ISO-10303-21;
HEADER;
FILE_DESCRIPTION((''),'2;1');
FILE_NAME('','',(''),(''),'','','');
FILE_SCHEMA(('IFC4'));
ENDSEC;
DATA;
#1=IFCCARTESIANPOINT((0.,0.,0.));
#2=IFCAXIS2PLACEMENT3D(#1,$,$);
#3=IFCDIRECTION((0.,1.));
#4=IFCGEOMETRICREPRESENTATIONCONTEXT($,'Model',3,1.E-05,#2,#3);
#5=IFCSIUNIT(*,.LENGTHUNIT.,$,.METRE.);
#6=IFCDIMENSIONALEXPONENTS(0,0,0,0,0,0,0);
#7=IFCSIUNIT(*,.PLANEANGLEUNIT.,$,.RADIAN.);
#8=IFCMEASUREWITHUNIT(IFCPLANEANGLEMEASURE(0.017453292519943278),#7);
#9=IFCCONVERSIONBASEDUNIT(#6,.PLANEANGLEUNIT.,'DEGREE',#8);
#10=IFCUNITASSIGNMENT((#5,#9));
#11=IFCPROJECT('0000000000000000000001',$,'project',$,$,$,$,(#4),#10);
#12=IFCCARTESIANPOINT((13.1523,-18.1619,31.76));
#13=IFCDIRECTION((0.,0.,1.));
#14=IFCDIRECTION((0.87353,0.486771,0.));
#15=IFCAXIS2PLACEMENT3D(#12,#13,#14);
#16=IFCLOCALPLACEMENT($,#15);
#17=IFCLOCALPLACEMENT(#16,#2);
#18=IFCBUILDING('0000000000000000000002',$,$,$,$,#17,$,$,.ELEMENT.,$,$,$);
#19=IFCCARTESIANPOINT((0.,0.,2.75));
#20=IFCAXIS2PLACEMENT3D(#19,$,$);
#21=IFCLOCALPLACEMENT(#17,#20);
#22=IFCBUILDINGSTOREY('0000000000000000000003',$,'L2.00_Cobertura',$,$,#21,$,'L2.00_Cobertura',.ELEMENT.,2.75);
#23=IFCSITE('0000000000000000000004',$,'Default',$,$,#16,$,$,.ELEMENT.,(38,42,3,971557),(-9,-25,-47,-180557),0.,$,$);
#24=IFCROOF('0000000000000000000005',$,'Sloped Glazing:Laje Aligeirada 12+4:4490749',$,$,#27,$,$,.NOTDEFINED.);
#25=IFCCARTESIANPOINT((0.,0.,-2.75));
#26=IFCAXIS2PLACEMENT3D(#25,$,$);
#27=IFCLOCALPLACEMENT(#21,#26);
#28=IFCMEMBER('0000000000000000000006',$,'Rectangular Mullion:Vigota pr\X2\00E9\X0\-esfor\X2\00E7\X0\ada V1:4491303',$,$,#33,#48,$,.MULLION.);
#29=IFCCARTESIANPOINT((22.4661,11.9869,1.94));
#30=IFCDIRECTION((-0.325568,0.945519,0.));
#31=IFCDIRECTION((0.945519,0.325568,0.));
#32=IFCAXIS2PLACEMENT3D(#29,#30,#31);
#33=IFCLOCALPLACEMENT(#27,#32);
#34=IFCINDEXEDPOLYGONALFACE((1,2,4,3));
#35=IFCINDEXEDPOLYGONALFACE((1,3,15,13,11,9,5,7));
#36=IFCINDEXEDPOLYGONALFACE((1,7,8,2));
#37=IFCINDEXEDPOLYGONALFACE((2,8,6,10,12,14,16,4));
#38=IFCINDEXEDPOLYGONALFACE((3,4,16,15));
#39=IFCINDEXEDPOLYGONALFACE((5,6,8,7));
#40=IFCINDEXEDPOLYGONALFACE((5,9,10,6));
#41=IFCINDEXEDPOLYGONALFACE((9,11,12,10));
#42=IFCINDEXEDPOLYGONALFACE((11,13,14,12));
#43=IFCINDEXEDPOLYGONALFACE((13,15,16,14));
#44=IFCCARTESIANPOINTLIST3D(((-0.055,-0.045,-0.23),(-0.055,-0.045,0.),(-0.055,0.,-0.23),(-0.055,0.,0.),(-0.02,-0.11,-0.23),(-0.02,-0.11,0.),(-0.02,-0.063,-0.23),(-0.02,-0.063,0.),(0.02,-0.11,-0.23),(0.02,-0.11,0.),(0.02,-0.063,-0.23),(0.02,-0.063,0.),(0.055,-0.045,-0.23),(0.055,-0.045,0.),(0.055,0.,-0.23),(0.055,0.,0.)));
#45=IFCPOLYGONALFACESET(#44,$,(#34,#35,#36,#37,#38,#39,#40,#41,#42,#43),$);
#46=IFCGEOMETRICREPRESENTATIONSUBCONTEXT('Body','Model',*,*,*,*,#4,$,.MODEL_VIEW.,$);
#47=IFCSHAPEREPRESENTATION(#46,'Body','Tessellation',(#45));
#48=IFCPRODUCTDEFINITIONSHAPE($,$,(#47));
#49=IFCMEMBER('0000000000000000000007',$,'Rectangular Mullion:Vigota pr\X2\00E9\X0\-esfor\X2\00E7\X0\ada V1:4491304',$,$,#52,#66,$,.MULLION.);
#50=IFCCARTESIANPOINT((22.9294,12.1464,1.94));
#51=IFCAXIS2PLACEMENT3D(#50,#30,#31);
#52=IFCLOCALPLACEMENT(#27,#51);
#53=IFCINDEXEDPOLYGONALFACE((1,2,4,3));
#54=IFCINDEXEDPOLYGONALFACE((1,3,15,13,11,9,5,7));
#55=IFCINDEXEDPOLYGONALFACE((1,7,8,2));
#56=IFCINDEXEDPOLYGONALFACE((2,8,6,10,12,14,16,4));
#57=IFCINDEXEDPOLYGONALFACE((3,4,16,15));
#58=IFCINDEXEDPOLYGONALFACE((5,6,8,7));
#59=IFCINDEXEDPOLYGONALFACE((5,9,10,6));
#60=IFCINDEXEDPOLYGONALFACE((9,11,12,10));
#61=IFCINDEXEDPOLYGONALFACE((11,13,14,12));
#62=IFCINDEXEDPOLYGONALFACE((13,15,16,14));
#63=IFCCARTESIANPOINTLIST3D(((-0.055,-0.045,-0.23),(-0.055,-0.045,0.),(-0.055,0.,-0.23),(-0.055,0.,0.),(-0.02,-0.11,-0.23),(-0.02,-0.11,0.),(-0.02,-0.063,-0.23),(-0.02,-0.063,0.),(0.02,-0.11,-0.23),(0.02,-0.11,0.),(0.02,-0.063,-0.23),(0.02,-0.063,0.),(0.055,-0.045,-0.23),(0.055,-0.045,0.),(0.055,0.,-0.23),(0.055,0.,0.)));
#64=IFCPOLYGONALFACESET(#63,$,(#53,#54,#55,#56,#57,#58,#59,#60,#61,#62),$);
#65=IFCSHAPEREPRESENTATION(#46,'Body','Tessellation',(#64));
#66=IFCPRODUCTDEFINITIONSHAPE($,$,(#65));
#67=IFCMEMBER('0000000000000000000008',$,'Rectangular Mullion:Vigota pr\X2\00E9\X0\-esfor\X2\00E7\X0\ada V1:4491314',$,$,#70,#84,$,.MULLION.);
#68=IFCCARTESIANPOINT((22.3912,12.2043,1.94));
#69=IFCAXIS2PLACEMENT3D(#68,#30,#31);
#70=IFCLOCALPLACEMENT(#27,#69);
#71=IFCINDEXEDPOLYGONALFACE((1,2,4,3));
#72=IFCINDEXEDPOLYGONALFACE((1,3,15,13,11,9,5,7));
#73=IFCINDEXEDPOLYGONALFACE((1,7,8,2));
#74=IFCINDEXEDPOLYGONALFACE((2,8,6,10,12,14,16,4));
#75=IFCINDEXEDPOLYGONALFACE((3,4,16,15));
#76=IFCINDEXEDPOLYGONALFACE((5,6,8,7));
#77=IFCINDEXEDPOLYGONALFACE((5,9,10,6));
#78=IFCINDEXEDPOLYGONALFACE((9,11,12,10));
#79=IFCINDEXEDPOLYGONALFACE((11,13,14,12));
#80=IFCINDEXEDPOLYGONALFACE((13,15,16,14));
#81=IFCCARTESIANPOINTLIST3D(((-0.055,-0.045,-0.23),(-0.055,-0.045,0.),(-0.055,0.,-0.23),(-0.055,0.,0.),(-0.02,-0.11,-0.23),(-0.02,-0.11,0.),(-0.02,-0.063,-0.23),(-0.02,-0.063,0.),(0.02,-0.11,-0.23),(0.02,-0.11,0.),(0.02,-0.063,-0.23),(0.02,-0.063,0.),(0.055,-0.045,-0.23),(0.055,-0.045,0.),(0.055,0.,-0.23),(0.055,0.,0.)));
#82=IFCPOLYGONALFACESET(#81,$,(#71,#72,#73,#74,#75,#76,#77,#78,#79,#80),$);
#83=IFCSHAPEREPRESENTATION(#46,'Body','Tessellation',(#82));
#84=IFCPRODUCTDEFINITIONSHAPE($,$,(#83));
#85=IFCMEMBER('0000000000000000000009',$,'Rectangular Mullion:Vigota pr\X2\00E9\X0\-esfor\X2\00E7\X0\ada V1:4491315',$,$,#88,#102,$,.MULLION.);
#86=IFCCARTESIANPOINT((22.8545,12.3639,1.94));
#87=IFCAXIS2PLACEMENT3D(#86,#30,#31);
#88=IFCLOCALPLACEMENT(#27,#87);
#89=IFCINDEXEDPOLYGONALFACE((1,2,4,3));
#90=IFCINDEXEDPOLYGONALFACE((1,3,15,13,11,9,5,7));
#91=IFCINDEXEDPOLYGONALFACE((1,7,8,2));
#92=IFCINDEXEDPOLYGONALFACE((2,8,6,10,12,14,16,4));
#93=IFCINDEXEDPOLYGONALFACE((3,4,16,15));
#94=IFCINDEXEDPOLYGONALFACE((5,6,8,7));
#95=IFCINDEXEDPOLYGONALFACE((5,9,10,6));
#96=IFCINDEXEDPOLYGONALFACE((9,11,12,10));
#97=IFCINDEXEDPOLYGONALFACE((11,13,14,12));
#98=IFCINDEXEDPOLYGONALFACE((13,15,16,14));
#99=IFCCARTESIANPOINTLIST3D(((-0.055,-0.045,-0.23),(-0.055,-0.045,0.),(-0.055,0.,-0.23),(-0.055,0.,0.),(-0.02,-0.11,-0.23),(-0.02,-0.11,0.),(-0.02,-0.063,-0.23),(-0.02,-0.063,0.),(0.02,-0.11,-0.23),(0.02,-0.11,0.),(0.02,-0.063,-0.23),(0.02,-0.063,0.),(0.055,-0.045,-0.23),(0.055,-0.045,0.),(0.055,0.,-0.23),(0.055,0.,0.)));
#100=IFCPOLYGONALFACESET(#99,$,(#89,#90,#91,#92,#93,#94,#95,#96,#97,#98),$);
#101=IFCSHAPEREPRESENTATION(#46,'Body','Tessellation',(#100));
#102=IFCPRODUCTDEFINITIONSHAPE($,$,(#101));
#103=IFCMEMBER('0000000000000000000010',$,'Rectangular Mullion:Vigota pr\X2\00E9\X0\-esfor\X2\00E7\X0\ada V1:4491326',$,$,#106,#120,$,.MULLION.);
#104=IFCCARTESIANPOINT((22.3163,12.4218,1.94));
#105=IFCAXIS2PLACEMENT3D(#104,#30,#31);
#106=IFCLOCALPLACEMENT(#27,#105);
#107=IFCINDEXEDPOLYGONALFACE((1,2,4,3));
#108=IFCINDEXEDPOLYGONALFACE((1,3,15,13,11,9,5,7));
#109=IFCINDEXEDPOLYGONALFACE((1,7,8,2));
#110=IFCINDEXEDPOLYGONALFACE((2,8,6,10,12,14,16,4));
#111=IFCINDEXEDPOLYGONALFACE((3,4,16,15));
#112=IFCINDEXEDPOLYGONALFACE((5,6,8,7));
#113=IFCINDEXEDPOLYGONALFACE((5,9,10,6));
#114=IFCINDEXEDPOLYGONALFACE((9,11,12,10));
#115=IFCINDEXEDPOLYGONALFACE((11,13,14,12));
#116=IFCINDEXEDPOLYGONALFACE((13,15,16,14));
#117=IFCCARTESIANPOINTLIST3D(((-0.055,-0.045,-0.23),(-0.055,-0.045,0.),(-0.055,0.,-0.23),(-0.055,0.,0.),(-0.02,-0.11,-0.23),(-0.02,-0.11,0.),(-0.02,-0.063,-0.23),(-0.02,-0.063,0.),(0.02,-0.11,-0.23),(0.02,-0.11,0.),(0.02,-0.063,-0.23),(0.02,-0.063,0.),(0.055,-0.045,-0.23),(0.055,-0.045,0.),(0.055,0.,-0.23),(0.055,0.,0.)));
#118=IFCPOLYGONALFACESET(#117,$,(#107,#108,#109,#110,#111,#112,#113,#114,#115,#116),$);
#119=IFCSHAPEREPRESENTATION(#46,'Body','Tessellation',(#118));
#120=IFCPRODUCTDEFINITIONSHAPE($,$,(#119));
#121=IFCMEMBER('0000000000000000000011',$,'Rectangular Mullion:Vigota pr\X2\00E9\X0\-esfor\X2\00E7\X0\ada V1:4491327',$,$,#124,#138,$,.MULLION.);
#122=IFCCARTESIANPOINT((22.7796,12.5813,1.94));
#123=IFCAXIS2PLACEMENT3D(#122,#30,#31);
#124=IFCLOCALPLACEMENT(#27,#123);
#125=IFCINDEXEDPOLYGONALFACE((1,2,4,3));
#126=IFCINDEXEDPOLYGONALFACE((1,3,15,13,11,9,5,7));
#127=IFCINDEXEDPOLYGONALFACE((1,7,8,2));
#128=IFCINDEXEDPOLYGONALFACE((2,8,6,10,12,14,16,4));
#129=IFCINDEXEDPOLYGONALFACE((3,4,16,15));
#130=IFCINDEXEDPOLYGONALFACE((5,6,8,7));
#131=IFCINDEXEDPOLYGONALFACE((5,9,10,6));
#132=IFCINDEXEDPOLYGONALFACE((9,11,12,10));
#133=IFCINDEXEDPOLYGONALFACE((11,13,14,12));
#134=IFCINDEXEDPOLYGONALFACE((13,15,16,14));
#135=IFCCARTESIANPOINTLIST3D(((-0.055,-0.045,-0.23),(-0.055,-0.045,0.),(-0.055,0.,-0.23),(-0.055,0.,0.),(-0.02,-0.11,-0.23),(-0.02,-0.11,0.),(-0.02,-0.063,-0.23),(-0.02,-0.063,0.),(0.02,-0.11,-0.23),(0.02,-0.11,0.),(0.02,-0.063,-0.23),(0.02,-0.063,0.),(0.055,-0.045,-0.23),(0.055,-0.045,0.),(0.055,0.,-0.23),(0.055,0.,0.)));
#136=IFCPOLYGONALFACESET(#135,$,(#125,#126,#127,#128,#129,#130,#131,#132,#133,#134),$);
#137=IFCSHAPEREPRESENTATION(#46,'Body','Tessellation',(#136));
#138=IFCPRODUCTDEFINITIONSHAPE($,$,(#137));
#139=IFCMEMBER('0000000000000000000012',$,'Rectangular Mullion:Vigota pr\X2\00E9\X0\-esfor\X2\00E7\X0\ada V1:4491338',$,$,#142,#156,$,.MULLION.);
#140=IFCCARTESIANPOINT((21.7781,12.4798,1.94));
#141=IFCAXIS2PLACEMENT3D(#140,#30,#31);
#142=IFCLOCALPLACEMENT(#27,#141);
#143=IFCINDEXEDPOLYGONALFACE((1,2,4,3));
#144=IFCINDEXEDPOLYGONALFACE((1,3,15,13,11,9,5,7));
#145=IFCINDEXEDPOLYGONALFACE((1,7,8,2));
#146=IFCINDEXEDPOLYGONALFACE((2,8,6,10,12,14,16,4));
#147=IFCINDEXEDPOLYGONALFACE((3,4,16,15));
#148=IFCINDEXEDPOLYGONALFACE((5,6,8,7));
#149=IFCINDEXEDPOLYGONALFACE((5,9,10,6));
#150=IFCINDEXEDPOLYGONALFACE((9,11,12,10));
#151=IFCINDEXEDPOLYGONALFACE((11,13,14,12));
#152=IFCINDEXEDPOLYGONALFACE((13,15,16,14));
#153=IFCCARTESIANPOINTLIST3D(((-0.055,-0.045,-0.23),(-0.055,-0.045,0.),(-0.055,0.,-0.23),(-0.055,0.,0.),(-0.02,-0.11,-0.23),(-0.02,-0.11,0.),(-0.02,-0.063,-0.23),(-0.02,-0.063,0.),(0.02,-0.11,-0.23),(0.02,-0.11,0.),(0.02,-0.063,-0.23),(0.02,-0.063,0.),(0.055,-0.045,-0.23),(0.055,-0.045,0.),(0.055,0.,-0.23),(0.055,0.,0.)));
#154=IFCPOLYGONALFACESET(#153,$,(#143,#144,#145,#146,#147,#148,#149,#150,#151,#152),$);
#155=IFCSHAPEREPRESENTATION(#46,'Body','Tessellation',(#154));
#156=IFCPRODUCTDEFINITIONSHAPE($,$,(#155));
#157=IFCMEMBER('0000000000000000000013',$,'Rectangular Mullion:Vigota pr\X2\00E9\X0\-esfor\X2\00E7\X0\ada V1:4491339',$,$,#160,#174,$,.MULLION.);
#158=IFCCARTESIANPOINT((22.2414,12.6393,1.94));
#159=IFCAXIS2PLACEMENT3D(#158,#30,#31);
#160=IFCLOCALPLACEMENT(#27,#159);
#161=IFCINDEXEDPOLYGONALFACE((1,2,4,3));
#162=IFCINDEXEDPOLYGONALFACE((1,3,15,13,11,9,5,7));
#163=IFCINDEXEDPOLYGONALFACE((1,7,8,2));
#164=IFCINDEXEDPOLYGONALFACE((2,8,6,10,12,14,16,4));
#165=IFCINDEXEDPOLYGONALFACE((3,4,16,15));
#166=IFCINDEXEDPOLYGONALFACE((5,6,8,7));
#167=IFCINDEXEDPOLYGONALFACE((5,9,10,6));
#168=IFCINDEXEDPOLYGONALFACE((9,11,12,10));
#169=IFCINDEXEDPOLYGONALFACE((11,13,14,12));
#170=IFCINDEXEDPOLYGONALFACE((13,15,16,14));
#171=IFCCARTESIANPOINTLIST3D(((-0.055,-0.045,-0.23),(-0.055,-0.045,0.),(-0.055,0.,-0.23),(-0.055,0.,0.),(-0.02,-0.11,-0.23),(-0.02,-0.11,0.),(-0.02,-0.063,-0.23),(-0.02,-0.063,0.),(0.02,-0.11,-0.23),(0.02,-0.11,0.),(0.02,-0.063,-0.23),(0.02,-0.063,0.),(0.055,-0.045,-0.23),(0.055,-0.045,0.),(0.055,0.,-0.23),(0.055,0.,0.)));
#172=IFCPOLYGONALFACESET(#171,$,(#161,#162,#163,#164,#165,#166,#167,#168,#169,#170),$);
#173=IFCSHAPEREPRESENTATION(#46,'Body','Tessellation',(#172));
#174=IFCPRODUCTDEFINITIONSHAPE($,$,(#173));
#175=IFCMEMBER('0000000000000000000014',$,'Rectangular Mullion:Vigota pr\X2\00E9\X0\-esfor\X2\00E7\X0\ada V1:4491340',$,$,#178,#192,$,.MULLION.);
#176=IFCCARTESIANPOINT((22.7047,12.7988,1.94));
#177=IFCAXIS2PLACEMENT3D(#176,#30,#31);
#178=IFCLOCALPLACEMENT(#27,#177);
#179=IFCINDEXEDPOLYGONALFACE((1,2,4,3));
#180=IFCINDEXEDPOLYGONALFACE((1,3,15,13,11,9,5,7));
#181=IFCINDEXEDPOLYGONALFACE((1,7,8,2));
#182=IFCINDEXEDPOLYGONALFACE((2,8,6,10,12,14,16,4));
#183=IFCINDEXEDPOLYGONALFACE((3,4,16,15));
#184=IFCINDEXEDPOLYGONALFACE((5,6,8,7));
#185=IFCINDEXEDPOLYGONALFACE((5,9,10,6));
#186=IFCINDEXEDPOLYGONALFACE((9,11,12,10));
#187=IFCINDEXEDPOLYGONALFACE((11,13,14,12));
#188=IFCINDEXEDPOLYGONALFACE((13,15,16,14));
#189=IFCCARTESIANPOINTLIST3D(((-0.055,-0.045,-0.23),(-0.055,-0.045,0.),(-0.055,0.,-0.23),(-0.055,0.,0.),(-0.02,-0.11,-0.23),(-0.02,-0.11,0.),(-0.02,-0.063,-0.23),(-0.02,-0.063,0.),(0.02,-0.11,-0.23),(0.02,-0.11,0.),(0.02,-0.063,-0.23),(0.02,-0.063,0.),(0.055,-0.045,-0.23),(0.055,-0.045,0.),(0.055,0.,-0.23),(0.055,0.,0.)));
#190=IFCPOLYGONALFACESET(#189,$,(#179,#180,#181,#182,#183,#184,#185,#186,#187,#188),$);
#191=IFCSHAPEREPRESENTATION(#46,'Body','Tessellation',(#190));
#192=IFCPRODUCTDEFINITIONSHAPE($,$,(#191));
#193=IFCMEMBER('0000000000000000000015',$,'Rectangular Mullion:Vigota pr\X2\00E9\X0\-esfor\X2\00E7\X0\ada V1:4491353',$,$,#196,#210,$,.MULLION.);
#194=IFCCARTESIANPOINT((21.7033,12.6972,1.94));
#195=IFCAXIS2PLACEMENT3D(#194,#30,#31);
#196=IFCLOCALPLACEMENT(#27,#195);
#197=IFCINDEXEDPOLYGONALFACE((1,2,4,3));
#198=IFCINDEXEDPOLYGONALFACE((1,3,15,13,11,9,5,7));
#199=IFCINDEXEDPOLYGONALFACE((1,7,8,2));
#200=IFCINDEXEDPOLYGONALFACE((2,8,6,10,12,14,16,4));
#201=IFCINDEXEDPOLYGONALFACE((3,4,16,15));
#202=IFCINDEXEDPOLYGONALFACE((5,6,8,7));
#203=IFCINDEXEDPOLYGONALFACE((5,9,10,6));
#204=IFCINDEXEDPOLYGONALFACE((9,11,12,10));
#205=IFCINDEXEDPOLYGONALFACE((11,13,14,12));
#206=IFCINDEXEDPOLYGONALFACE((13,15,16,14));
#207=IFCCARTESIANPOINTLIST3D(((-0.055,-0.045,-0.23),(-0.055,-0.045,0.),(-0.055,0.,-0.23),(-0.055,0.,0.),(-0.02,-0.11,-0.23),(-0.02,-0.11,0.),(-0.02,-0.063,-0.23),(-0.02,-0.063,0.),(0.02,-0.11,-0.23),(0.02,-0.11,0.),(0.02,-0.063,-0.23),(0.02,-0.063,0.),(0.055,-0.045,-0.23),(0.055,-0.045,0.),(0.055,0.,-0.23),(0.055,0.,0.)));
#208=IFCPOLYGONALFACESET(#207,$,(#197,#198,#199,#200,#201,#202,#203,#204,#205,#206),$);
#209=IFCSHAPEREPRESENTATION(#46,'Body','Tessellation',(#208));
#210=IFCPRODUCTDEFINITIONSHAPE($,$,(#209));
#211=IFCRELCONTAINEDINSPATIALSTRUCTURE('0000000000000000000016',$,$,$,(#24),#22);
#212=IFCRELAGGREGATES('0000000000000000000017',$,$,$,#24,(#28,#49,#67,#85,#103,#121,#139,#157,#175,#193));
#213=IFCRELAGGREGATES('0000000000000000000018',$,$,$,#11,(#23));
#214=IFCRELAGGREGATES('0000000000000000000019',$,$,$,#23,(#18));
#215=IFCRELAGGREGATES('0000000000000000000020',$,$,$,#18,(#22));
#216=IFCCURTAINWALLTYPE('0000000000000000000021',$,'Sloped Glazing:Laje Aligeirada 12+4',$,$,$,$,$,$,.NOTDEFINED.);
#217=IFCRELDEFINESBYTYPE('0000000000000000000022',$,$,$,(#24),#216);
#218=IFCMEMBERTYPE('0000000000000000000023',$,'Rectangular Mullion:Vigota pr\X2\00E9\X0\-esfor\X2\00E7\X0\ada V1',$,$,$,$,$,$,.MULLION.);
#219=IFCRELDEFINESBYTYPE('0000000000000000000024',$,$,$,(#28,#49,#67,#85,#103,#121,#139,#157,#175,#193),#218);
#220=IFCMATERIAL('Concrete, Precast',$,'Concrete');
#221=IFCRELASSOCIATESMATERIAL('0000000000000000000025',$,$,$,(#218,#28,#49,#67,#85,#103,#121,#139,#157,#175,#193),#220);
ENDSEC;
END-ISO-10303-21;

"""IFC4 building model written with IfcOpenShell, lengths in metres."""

from ifc_helpers import new_model, entity, si_unit, converted_unit, direction, frame, origin, place, context, subcontext, project, spatial, indexed_curve, outline, extrude, source, transform, mapped, material, type_object, type_shapes, element, aggregate, save


model = new_model("IFC4")

# Units and contexts
model_context = context("Model", 3, precision=1e-05, world=origin(), true_north=direction((0.0, 1.0)))
body_context = subcontext(model_context, "Body", "Model", "MODEL_VIEW")
ifc_project = project(units=[si_unit("LENGTHUNIT", "METRE"), converted_unit("PLANEANGLEUNIT", "DEGREE", entity("IfcPlaneAngleMeasure", 0.017453292519943278), si_unit("PLANEANGLEUNIT", "RADIAN"), dimensions=[0, 0, 0, 0, 0, 0, 0])], contexts=[model_context])

# Site, building, storey
site_placement = place(None, frame((13.1523, -18.1619, 31.76), z_axis=(0.0, 0.0, 1.0), x_axis=(0.87353, 0.486771, 0.0)))
site = spatial("IfcSite", under=ifc_project, at=site_placement, Name="Default", CompositionType="ELEMENT", RefLatitude=(38, 42, 3, 971557), RefLongitude=(-9, -25, -47, -180557), RefElevation=0.0)
building_placement = place(site_placement, origin())
building = spatial("IfcBuilding", under=site, at=building_placement, CompositionType="ELEMENT")
storey_placement = place(building_placement, frame((0.0, 0.0, 2.75)))
storey = spatial("IfcBuildingStorey", under=building, at=storey_placement, Name="L2.00_Cobertura", LongName="L2.00_Cobertura", CompositionType="ELEMENT", Elevation=2.75)

# Roof, members
curtain_wall_type = type_object("IfcCurtainWallType", Name="Sloped Glazing:Laje Aligeirada 12+4", PredefinedType="NOTDEFINED")
roof_placement = place(storey_placement, frame((0.0, 0.0, -2.75)))
roof = element("IfcRoof", 1, at=roof_placement, inside=storey, type_object=curtain_wall_type, Name="Sloped Glazing:Laje Aligeirada 12+4:4490749", PredefinedType="NOTDEFINED")
ifc_material_1 = material(Name="Concrete, Precast", Category="Concrete")
member_type = type_object("IfcMemberType", Name="Rectangular Mullion:Vigota pré-esforçada V1", PredefinedType="MULLION", material=ifc_material_1)
shared_shape_1 = source(origin(), body_context, "Body", "SweptSolid", [
    extrude(outline(indexed_curve([(-0.055, -0.0545), (0.055, -0.0545), (0.055, -0.0095), (0.02, 0.0085), (0.02, 0.0555), (-0.02, 0.0555), (-0.02, 0.0085), (-0.055, -0.0095), (-0.055, -0.0545)], self_intersect=False)), frame((0.0, -0.0545, -0.23), z_axis=(0.0, 0.0, 1.0), x_axis=(-1.0, 0.0, 0.0)), (0.0, 0.0, 1.0), 0.23),
])
type_shapes(member_type, [shared_shape_1])
member_1_placement = place(roof_placement, frame((22.4661, 11.9869, 1.94), z_axis=(-0.325568, 0.945519, 0.0), x_axis=(0.945519, 0.325568, 0.0)))
member_1 = element("IfcMember", 2, at=member_1_placement, type_object=member_type, material=ifc_material_1, Name="Rectangular Mullion:Vigota pré-esforçada V1:4491303", PredefinedType="MULLION", context=body_context, shape_type="MappedRepresentation", body=[
    mapped(shared_shape_1, transform((0.0, 0.0, 0.0), scale=1.0)),
])
member_2_placement = place(roof_placement, frame((22.9294, 12.1464, 1.94), z_axis=(-0.325568, 0.945519, 0.0), x_axis=(0.945519, 0.325568, 0.0)))
member_2 = element("IfcMember", 3, at=member_2_placement, type_object=member_type, material=ifc_material_1, Name="Rectangular Mullion:Vigota pré-esforçada V1:4491304", PredefinedType="MULLION", context=body_context, shape_type="MappedRepresentation", body=[
    mapped(shared_shape_1, transform((0.0, 0.0, 0.0), scale=1.0)),
])
member_3_placement = place(roof_placement, frame((22.3912, 12.2043, 1.94), z_axis=(-0.325568, 0.945519, 0.0), x_axis=(0.945519, 0.325568, 0.0)))
member_3 = element("IfcMember", 4, at=member_3_placement, type_object=member_type, material=ifc_material_1, Name="Rectangular Mullion:Vigota pré-esforçada V1:4491314", PredefinedType="MULLION", context=body_context, shape_type="MappedRepresentation", body=[
    mapped(shared_shape_1, transform((0.0, 0.0, 0.0), scale=1.0)),
])
member_4_placement = place(roof_placement, frame((22.8545, 12.3639, 1.94), z_axis=(-0.325568, 0.945519, 0.0), x_axis=(0.945519, 0.325568, 0.0)))
member_4 = element("IfcMember", 5, at=member_4_placement, type_object=member_type, material=ifc_material_1, Name="Rectangular Mullion:Vigota pré-esforçada V1:4491315", PredefinedType="MULLION", context=body_context, shape_type="MappedRepresentation", body=[
    mapped(shared_shape_1, transform((0.0, 0.0, 0.0), scale=1.0)),
])
member_5_placement = place(roof_placement, frame((22.3163, 12.4218, 1.94), z_axis=(-0.325568, 0.945519, 0.0), x_axis=(0.945519, 0.325568, 0.0)))
member_5 = element("IfcMember", 6, at=member_5_placement, type_object=member_type, material=ifc_material_1, Name="Rectangular Mullion:Vigota pré-esforçada V1:4491326", PredefinedType="MULLION", context=body_context, shape_type="MappedRepresentation", body=[
    mapped(shared_shape_1, transform((0.0, 0.0, 0.0), scale=1.0)),
])
member_6_placement = place(roof_placement, frame((22.7796, 12.5813, 1.94), z_axis=(-0.325568, 0.945519, 0.0), x_axis=(0.945519, 0.325568, 0.0)))
member_6 = element("IfcMember", 7, at=member_6_placement, type_object=member_type, material=ifc_material_1, Name="Rectangular Mullion:Vigota pré-esforçada V1:4491327", PredefinedType="MULLION", context=body_context, shape_type="MappedRepresentation", body=[
    mapped(shared_shape_1, transform((0.0, 0.0, 0.0), scale=1.0)),
])
member_7_placement = place(roof_placement, frame((21.7781, 12.4798, 1.94), z_axis=(-0.325568, 0.945519, 0.0), x_axis=(0.945519, 0.325568, 0.0)))
member_7 = element("IfcMember", 8, at=member_7_placement, type_object=member_type, material=ifc_material_1, Name="Rectangular Mullion:Vigota pré-esforçada V1:4491338", PredefinedType="MULLION", context=body_context, shape_type="MappedRepresentation", body=[
    mapped(shared_shape_1, transform((0.0, 0.0, 0.0), scale=1.0)),
])
member_8_placement = place(roof_placement, frame((22.2414, 12.6393, 1.94), z_axis=(-0.325568, 0.945519, 0.0), x_axis=(0.945519, 0.325568, 0.0)))
member_8 = element("IfcMember", 9, at=member_8_placement, type_object=member_type, material=ifc_material_1, Name="Rectangular Mullion:Vigota pré-esforçada V1:4491339", PredefinedType="MULLION", context=body_context, shape_type="MappedRepresentation", body=[
    mapped(shared_shape_1, transform((0.0, 0.0, 0.0), scale=1.0)),
])
member_9_placement = place(roof_placement, frame((22.7047, 12.7988, 1.94), z_axis=(-0.325568, 0.945519, 0.0), x_axis=(0.945519, 0.325568, 0.0)))
member_9 = element("IfcMember", 10, at=member_9_placement, type_object=member_type, material=ifc_material_1, Name="Rectangular Mullion:Vigota pré-esforçada V1:4491340", PredefinedType="MULLION", context=body_context, shape_type="MappedRepresentation", body=[
    mapped(shared_shape_1, transform((0.0, 0.0, 0.0), scale=1.0)),
])
member_10_placement = place(roof_placement, frame((21.7033, 12.6972, 1.94), z_axis=(-0.325568, 0.945519, 0.0), x_axis=(0.945519, 0.325568, 0.0)))
member_10 = element("IfcMember", 11, at=member_10_placement, type_object=member_type, material=ifc_material_1, Name="Rectangular Mullion:Vigota pré-esforçada V1:4491353", PredefinedType="MULLION", context=body_context, shape_type="MappedRepresentation", body=[
    mapped(shared_shape_1, transform((0.0, 0.0, 0.0), scale=1.0)),
])
aggregate(roof, [member_1, member_2, member_3, member_4, member_5, member_6, member_7, member_8, member_9, member_10])

save(model, "model.ifc")
